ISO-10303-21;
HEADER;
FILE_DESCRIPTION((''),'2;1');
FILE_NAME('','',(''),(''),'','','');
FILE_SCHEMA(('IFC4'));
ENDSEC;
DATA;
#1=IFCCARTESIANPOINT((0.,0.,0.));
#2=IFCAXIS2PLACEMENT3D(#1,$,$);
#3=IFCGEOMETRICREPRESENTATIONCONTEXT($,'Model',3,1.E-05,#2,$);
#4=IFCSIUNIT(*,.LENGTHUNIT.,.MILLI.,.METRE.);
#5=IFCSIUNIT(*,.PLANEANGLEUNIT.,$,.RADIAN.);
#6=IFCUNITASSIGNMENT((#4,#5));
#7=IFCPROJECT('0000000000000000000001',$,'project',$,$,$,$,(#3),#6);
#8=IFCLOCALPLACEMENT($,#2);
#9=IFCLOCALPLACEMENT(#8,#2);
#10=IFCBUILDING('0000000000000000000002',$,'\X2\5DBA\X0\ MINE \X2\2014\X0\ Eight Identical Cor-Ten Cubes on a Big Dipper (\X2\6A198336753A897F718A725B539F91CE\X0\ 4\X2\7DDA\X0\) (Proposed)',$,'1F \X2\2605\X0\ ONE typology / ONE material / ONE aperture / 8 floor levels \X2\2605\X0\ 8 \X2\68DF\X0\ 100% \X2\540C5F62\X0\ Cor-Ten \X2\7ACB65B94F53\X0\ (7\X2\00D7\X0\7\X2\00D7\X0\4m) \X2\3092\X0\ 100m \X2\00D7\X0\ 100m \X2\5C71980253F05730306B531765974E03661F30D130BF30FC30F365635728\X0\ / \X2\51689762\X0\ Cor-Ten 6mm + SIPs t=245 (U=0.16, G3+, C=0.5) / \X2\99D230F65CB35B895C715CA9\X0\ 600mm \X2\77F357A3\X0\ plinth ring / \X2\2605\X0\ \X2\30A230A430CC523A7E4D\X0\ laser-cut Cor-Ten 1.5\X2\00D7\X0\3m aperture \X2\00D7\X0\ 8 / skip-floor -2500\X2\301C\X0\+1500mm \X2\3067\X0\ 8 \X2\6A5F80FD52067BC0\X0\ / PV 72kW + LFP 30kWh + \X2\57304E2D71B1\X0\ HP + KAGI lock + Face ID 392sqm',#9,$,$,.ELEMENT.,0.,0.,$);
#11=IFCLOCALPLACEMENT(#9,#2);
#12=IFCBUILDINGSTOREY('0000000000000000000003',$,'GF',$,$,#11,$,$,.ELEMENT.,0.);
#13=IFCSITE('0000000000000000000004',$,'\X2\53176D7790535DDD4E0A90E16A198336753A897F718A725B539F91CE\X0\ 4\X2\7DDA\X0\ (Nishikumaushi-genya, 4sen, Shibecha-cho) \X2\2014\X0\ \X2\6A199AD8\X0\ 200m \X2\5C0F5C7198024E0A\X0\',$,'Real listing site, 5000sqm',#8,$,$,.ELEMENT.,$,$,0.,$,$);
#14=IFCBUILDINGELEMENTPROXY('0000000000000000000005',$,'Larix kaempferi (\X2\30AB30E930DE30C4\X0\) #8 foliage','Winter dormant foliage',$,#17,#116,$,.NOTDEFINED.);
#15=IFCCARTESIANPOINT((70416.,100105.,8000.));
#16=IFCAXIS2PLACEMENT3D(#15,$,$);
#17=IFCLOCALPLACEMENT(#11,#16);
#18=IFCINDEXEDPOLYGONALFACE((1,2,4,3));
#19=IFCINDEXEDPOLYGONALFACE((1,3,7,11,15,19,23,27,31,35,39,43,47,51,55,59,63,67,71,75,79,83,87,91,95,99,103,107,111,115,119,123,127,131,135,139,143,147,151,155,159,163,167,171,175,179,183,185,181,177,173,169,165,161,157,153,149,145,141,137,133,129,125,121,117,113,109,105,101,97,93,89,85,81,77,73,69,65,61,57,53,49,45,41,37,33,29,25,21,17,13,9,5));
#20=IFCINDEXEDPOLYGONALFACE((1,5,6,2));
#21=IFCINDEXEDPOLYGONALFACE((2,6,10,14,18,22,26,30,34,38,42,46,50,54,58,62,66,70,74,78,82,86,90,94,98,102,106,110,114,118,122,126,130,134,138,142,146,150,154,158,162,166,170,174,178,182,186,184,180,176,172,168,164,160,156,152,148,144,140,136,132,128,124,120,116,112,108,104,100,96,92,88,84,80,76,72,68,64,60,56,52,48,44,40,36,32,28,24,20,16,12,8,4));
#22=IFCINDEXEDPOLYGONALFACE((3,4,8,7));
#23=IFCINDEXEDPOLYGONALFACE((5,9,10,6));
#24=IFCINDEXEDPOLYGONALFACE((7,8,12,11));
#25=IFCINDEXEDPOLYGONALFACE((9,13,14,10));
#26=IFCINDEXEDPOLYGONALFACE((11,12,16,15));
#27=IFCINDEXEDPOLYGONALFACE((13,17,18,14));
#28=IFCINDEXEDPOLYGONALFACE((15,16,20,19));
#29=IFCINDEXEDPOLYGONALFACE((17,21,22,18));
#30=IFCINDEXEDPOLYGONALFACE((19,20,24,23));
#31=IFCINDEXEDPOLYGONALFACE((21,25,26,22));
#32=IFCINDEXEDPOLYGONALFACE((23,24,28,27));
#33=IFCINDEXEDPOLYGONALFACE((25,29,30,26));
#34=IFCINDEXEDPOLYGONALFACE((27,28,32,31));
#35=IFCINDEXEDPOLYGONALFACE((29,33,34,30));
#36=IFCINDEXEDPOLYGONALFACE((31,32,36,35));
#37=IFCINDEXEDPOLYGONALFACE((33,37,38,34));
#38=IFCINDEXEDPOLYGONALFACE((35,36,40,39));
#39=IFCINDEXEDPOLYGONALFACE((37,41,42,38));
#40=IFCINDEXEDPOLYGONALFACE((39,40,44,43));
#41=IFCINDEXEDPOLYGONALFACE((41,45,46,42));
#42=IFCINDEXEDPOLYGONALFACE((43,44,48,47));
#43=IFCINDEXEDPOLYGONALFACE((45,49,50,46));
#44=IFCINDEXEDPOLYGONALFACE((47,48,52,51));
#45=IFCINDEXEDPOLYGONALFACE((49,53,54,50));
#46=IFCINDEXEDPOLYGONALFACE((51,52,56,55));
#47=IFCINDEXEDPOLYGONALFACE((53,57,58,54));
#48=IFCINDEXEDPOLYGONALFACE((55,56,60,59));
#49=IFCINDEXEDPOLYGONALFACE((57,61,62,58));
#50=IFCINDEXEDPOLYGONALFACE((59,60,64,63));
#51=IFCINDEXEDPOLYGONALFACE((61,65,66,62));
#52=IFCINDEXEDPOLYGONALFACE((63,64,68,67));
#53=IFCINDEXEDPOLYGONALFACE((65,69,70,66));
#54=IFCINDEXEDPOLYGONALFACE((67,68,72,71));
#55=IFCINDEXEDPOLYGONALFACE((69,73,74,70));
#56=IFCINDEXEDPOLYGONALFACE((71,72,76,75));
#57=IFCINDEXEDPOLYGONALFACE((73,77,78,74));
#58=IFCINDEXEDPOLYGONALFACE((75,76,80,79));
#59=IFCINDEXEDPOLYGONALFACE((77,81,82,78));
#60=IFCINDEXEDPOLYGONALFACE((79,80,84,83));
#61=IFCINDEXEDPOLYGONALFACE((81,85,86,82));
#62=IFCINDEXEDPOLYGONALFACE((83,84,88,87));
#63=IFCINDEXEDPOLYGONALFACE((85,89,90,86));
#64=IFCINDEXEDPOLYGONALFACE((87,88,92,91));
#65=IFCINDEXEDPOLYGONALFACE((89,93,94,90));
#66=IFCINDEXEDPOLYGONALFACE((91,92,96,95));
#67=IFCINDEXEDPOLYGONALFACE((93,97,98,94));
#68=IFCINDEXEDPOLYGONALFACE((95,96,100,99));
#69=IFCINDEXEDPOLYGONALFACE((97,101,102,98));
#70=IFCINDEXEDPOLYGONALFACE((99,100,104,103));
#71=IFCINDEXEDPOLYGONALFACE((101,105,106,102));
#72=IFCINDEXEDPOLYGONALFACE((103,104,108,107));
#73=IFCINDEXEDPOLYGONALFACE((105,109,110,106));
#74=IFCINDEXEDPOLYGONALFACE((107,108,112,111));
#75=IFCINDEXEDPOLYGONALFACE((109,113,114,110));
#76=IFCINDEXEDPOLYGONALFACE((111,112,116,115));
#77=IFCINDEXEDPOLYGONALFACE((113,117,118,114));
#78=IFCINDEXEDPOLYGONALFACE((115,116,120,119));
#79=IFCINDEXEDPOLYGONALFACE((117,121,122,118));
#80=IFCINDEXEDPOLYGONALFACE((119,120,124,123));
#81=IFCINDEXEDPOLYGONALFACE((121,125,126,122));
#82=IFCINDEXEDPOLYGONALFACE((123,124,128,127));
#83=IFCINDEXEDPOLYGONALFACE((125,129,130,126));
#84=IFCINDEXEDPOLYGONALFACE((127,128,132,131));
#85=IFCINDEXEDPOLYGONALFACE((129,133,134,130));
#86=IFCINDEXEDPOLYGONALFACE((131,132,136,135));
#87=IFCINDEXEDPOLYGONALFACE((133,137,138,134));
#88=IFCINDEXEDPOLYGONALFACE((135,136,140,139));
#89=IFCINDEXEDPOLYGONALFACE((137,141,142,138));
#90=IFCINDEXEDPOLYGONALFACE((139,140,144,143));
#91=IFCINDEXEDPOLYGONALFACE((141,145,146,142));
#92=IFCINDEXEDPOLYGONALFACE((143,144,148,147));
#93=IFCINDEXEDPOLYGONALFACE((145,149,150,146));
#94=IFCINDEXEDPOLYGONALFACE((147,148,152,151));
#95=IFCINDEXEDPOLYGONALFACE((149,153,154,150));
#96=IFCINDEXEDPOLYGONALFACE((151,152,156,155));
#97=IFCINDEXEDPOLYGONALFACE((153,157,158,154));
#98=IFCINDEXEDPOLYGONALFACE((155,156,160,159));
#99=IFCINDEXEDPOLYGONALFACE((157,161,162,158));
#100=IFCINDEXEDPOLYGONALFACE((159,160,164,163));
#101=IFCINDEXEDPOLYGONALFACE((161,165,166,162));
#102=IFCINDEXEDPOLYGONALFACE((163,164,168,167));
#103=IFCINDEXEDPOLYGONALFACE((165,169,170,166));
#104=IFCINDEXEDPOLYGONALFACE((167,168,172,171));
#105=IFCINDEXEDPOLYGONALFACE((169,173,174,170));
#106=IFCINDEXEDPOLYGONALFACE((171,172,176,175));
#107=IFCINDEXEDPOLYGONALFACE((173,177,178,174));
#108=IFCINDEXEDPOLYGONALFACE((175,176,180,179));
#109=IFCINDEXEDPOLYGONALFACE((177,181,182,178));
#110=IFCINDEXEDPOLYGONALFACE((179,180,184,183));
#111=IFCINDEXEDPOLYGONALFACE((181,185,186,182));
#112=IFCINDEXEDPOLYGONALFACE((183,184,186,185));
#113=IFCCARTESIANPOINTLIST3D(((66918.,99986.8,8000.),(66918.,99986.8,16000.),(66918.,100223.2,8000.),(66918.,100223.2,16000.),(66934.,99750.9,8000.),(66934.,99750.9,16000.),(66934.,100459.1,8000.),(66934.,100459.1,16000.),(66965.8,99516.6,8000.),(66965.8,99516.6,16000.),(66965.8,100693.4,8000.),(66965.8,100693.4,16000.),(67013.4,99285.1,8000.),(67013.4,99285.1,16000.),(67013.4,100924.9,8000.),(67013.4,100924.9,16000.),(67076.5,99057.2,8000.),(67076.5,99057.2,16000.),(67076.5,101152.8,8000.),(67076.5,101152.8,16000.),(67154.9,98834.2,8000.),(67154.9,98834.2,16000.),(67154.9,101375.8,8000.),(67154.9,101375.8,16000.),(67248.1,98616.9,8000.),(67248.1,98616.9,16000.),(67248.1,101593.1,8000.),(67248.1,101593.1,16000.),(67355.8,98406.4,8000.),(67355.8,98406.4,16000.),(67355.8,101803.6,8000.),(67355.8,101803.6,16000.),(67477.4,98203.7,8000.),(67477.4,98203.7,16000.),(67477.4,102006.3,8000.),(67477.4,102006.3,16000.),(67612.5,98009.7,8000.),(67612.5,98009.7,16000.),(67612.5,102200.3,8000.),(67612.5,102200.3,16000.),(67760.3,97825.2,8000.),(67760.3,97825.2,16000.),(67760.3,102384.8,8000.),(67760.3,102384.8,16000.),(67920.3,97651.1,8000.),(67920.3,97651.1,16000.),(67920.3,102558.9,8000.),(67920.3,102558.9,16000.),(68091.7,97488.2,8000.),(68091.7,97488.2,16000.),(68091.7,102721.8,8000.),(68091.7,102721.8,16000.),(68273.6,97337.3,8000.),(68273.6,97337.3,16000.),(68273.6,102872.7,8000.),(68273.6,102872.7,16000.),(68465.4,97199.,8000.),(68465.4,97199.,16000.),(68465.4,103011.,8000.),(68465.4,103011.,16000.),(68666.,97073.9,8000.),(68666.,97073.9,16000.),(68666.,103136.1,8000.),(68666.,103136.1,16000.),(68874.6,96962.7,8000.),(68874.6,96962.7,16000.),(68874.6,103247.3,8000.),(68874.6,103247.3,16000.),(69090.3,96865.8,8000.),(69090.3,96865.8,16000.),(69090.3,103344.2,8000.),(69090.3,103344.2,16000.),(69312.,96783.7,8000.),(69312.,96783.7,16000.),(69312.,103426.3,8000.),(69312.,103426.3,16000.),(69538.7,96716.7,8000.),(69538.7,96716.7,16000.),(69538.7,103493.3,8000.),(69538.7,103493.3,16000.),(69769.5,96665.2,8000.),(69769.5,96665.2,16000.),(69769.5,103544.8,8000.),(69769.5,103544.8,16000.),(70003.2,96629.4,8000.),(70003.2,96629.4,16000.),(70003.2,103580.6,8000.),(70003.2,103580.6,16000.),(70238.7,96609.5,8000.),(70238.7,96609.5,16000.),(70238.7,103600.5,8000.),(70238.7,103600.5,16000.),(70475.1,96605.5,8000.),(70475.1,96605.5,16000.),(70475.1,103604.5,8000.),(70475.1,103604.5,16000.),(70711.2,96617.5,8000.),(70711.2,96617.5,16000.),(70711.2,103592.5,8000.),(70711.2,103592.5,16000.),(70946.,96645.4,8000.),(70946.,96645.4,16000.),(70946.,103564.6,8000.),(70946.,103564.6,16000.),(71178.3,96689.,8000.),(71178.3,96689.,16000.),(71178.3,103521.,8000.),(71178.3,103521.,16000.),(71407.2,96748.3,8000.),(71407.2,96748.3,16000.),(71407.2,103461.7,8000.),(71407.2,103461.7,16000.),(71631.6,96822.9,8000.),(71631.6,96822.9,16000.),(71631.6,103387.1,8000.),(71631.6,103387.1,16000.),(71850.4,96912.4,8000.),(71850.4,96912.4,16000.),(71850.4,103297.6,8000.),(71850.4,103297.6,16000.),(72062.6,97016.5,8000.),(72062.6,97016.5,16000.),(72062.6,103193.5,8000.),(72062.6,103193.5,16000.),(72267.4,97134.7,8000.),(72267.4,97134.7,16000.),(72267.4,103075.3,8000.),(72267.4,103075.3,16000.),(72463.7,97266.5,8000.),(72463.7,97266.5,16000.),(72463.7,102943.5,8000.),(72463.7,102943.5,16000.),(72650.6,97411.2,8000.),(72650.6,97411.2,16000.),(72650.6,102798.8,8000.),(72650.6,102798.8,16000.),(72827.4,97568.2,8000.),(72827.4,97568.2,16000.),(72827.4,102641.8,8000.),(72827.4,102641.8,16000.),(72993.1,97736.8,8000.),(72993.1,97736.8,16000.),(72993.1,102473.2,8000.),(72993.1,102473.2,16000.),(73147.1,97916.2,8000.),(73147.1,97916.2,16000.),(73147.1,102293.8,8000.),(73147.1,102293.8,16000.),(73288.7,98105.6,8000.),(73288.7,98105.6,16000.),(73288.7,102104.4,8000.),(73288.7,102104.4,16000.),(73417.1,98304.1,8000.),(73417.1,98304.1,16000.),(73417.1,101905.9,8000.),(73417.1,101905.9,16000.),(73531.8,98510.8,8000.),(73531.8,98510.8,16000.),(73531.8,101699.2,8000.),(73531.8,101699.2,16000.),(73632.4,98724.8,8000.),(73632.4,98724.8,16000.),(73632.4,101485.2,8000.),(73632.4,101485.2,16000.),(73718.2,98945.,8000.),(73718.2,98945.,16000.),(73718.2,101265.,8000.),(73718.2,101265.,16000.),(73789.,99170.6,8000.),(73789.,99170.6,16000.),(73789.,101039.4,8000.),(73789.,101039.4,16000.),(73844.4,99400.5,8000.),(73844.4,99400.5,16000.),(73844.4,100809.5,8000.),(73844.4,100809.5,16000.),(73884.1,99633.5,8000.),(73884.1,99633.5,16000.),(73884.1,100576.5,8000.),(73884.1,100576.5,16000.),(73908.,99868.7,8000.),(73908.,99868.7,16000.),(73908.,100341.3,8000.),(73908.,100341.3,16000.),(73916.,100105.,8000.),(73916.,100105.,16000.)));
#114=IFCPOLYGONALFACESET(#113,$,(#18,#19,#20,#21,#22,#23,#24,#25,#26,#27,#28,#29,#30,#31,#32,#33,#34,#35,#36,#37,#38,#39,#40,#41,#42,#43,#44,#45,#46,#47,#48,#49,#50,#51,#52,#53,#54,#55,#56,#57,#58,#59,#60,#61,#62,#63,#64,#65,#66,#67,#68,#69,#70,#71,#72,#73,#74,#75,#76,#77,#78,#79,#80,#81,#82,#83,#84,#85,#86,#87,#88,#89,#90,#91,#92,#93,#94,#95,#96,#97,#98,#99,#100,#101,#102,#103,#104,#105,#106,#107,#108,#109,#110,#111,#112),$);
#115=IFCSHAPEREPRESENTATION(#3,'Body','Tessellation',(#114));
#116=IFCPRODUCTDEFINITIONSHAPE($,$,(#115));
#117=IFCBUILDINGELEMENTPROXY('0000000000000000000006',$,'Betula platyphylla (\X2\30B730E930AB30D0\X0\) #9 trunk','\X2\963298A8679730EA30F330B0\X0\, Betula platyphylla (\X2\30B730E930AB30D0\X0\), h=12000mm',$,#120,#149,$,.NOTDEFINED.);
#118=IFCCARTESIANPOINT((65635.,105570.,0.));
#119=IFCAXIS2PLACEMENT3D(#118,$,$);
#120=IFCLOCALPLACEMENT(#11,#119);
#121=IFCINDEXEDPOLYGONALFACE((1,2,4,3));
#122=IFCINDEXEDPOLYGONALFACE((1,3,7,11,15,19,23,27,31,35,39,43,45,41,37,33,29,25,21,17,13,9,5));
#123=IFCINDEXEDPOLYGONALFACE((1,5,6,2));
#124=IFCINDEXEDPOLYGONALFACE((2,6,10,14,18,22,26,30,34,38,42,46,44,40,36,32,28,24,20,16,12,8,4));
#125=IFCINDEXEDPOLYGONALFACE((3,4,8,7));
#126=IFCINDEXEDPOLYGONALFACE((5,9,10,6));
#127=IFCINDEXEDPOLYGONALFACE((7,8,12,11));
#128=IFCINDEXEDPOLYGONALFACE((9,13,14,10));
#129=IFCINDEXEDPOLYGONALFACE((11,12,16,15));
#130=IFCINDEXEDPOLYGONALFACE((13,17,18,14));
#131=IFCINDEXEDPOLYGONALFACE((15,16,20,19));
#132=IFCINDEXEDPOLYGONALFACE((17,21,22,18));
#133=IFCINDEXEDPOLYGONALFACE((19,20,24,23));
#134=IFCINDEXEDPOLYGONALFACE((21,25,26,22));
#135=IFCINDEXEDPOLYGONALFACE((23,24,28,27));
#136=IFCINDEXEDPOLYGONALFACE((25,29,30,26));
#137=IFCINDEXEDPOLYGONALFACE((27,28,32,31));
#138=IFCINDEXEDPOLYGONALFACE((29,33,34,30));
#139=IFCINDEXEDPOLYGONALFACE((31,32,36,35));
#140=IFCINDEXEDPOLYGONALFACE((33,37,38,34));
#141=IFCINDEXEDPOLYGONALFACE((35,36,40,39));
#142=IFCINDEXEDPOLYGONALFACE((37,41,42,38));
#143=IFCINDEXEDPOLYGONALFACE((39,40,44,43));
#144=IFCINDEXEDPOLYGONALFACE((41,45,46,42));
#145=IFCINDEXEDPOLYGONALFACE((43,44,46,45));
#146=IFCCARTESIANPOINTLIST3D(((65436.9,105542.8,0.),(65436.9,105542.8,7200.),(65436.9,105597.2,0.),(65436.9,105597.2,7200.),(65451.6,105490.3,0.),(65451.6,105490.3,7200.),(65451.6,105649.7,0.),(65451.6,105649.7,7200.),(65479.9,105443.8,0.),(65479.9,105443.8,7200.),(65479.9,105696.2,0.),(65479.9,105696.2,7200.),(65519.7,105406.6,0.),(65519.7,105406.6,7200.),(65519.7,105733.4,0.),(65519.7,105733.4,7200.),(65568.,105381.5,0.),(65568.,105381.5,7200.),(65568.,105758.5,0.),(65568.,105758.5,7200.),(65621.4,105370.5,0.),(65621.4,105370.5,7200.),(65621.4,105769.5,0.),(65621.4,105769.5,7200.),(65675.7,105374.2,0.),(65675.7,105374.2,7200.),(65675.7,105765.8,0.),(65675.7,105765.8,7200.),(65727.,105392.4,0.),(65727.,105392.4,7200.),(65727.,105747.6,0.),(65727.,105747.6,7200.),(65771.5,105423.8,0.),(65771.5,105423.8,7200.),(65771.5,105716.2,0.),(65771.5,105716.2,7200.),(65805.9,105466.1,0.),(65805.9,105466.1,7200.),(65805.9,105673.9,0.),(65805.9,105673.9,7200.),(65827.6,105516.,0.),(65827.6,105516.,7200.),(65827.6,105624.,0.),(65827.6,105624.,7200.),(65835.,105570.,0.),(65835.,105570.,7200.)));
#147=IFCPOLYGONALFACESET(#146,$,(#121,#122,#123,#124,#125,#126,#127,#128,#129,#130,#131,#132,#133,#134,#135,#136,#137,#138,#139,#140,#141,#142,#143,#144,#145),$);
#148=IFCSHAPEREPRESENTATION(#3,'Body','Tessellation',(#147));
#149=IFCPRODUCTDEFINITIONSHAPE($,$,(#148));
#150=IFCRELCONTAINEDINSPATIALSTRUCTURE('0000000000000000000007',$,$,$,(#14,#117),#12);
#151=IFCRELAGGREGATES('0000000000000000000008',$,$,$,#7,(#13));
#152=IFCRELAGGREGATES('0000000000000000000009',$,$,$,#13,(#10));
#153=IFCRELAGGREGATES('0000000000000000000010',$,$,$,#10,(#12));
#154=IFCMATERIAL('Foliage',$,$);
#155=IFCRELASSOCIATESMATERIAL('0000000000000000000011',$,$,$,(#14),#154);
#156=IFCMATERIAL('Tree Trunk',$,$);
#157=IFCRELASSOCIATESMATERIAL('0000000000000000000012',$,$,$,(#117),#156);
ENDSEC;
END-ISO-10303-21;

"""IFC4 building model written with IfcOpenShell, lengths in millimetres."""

from ifc_helpers import new_model, si_unit, frame, origin, origin_2d, place, context, project, spatial, circle, extrude, material, element, save


model = new_model("IFC4")

# Units and contexts
model_context = context("Model", 3, precision=1e-05, world=origin())
ifc_project = project(units=[si_unit("LENGTHUNIT", "METRE", prefix="MILLI"), si_unit("PLANEANGLEUNIT", "RADIAN")], contexts=[model_context])

# Site, building, storey
site_placement = place(None, origin())
site = spatial("IfcSite", under=ifc_project, at=site_placement, Name="北海道川上郡標茶町西熊牛原野 4線 (Nishikumaushi-genya, 4sen, Shibecha-cho) — 標高 200m 小山頂上", ObjectType="Real listing site, 5000sqm", CompositionType="ELEMENT", RefElevation=0.0)
building_placement = place(site_placement, origin())
building = spatial("IfcBuilding", under=site, at=building_placement, Name="嶺 MINE — Eight Identical Cor-Ten Cubes on a Big Dipper (標茶町西熊牛原野 4線) (Proposed)", ObjectType="1F ★ ONE typology / ONE material / ONE aperture / 8 floor levels ★ 8 棟 100% 同形 Cor-Ten 立方体 (7×7×4m) を 100m × 100m 山頂台地に北斗七星パターン散在 / 全面 Cor-Ten 6mm + SIPs t=245 (U=0.16, G3+, C=0.5) / 駒ヶ岳安山岩 600mm 石垣 plinth ring / ★ アイヌ刺繍 laser-cut Cor-Ten 1.5×3m aperture × 8 / skip-floor -2500〜+1500mm で 8 機能分節 / PV 72kW + LFP 30kWh + 地中熱 HP + KAGI lock + Face ID 392sqm", CompositionType="ELEMENT", ElevationOfRefHeight=0.0, ElevationOfTerrain=0.0)
storey_placement = place(building_placement, origin())
storey = spatial("IfcBuildingStorey", under=building, at=storey_placement, Name="GF", CompositionType="ELEMENT", Elevation=0.0)

# Building element proxies
ifc_material_1 = material(Name="Tree Trunk")
ifc_material_2 = material(Name="Foliage")
proxy_1_placement = place(storey_placement, frame((70416.0, 100105.0, 8000.0)))
element("IfcBuildingElementProxy", 1, at=proxy_1_placement, inside=storey, material=ifc_material_2, Name="Larix kaempferi (カラマツ) #8 foliage", Description="Winter dormant foliage", PredefinedType="NOTDEFINED", context=model_context, shape_type="SweptSolid", body=[
    extrude(circle(Radius=3500.0, at=origin_2d()), frame((70416.0, 100105.0, 8000.0)), (0.0, 0.0, 1.0), 8000.0),
])
proxy_2_placement = place(storey_placement, frame((65635.0, 105570.0, 0.0)))
element("IfcBuildingElementProxy", 2, at=proxy_2_placement, inside=storey, material=ifc_material_1, Name="Betula platyphylla (シラカバ) #9 trunk", Description="防風林リング, Betula platyphylla (シラカバ), h=12000mm", PredefinedType="NOTDEFINED", context=model_context, shape_type="SweptSolid", body=[
    extrude(circle(Radius=200.0, at=origin_2d()), frame((65635.0, 105570.0, 0.0)), (0.0, 0.0, 1.0), 7200.0),
])

save(model, "model.ifc")
